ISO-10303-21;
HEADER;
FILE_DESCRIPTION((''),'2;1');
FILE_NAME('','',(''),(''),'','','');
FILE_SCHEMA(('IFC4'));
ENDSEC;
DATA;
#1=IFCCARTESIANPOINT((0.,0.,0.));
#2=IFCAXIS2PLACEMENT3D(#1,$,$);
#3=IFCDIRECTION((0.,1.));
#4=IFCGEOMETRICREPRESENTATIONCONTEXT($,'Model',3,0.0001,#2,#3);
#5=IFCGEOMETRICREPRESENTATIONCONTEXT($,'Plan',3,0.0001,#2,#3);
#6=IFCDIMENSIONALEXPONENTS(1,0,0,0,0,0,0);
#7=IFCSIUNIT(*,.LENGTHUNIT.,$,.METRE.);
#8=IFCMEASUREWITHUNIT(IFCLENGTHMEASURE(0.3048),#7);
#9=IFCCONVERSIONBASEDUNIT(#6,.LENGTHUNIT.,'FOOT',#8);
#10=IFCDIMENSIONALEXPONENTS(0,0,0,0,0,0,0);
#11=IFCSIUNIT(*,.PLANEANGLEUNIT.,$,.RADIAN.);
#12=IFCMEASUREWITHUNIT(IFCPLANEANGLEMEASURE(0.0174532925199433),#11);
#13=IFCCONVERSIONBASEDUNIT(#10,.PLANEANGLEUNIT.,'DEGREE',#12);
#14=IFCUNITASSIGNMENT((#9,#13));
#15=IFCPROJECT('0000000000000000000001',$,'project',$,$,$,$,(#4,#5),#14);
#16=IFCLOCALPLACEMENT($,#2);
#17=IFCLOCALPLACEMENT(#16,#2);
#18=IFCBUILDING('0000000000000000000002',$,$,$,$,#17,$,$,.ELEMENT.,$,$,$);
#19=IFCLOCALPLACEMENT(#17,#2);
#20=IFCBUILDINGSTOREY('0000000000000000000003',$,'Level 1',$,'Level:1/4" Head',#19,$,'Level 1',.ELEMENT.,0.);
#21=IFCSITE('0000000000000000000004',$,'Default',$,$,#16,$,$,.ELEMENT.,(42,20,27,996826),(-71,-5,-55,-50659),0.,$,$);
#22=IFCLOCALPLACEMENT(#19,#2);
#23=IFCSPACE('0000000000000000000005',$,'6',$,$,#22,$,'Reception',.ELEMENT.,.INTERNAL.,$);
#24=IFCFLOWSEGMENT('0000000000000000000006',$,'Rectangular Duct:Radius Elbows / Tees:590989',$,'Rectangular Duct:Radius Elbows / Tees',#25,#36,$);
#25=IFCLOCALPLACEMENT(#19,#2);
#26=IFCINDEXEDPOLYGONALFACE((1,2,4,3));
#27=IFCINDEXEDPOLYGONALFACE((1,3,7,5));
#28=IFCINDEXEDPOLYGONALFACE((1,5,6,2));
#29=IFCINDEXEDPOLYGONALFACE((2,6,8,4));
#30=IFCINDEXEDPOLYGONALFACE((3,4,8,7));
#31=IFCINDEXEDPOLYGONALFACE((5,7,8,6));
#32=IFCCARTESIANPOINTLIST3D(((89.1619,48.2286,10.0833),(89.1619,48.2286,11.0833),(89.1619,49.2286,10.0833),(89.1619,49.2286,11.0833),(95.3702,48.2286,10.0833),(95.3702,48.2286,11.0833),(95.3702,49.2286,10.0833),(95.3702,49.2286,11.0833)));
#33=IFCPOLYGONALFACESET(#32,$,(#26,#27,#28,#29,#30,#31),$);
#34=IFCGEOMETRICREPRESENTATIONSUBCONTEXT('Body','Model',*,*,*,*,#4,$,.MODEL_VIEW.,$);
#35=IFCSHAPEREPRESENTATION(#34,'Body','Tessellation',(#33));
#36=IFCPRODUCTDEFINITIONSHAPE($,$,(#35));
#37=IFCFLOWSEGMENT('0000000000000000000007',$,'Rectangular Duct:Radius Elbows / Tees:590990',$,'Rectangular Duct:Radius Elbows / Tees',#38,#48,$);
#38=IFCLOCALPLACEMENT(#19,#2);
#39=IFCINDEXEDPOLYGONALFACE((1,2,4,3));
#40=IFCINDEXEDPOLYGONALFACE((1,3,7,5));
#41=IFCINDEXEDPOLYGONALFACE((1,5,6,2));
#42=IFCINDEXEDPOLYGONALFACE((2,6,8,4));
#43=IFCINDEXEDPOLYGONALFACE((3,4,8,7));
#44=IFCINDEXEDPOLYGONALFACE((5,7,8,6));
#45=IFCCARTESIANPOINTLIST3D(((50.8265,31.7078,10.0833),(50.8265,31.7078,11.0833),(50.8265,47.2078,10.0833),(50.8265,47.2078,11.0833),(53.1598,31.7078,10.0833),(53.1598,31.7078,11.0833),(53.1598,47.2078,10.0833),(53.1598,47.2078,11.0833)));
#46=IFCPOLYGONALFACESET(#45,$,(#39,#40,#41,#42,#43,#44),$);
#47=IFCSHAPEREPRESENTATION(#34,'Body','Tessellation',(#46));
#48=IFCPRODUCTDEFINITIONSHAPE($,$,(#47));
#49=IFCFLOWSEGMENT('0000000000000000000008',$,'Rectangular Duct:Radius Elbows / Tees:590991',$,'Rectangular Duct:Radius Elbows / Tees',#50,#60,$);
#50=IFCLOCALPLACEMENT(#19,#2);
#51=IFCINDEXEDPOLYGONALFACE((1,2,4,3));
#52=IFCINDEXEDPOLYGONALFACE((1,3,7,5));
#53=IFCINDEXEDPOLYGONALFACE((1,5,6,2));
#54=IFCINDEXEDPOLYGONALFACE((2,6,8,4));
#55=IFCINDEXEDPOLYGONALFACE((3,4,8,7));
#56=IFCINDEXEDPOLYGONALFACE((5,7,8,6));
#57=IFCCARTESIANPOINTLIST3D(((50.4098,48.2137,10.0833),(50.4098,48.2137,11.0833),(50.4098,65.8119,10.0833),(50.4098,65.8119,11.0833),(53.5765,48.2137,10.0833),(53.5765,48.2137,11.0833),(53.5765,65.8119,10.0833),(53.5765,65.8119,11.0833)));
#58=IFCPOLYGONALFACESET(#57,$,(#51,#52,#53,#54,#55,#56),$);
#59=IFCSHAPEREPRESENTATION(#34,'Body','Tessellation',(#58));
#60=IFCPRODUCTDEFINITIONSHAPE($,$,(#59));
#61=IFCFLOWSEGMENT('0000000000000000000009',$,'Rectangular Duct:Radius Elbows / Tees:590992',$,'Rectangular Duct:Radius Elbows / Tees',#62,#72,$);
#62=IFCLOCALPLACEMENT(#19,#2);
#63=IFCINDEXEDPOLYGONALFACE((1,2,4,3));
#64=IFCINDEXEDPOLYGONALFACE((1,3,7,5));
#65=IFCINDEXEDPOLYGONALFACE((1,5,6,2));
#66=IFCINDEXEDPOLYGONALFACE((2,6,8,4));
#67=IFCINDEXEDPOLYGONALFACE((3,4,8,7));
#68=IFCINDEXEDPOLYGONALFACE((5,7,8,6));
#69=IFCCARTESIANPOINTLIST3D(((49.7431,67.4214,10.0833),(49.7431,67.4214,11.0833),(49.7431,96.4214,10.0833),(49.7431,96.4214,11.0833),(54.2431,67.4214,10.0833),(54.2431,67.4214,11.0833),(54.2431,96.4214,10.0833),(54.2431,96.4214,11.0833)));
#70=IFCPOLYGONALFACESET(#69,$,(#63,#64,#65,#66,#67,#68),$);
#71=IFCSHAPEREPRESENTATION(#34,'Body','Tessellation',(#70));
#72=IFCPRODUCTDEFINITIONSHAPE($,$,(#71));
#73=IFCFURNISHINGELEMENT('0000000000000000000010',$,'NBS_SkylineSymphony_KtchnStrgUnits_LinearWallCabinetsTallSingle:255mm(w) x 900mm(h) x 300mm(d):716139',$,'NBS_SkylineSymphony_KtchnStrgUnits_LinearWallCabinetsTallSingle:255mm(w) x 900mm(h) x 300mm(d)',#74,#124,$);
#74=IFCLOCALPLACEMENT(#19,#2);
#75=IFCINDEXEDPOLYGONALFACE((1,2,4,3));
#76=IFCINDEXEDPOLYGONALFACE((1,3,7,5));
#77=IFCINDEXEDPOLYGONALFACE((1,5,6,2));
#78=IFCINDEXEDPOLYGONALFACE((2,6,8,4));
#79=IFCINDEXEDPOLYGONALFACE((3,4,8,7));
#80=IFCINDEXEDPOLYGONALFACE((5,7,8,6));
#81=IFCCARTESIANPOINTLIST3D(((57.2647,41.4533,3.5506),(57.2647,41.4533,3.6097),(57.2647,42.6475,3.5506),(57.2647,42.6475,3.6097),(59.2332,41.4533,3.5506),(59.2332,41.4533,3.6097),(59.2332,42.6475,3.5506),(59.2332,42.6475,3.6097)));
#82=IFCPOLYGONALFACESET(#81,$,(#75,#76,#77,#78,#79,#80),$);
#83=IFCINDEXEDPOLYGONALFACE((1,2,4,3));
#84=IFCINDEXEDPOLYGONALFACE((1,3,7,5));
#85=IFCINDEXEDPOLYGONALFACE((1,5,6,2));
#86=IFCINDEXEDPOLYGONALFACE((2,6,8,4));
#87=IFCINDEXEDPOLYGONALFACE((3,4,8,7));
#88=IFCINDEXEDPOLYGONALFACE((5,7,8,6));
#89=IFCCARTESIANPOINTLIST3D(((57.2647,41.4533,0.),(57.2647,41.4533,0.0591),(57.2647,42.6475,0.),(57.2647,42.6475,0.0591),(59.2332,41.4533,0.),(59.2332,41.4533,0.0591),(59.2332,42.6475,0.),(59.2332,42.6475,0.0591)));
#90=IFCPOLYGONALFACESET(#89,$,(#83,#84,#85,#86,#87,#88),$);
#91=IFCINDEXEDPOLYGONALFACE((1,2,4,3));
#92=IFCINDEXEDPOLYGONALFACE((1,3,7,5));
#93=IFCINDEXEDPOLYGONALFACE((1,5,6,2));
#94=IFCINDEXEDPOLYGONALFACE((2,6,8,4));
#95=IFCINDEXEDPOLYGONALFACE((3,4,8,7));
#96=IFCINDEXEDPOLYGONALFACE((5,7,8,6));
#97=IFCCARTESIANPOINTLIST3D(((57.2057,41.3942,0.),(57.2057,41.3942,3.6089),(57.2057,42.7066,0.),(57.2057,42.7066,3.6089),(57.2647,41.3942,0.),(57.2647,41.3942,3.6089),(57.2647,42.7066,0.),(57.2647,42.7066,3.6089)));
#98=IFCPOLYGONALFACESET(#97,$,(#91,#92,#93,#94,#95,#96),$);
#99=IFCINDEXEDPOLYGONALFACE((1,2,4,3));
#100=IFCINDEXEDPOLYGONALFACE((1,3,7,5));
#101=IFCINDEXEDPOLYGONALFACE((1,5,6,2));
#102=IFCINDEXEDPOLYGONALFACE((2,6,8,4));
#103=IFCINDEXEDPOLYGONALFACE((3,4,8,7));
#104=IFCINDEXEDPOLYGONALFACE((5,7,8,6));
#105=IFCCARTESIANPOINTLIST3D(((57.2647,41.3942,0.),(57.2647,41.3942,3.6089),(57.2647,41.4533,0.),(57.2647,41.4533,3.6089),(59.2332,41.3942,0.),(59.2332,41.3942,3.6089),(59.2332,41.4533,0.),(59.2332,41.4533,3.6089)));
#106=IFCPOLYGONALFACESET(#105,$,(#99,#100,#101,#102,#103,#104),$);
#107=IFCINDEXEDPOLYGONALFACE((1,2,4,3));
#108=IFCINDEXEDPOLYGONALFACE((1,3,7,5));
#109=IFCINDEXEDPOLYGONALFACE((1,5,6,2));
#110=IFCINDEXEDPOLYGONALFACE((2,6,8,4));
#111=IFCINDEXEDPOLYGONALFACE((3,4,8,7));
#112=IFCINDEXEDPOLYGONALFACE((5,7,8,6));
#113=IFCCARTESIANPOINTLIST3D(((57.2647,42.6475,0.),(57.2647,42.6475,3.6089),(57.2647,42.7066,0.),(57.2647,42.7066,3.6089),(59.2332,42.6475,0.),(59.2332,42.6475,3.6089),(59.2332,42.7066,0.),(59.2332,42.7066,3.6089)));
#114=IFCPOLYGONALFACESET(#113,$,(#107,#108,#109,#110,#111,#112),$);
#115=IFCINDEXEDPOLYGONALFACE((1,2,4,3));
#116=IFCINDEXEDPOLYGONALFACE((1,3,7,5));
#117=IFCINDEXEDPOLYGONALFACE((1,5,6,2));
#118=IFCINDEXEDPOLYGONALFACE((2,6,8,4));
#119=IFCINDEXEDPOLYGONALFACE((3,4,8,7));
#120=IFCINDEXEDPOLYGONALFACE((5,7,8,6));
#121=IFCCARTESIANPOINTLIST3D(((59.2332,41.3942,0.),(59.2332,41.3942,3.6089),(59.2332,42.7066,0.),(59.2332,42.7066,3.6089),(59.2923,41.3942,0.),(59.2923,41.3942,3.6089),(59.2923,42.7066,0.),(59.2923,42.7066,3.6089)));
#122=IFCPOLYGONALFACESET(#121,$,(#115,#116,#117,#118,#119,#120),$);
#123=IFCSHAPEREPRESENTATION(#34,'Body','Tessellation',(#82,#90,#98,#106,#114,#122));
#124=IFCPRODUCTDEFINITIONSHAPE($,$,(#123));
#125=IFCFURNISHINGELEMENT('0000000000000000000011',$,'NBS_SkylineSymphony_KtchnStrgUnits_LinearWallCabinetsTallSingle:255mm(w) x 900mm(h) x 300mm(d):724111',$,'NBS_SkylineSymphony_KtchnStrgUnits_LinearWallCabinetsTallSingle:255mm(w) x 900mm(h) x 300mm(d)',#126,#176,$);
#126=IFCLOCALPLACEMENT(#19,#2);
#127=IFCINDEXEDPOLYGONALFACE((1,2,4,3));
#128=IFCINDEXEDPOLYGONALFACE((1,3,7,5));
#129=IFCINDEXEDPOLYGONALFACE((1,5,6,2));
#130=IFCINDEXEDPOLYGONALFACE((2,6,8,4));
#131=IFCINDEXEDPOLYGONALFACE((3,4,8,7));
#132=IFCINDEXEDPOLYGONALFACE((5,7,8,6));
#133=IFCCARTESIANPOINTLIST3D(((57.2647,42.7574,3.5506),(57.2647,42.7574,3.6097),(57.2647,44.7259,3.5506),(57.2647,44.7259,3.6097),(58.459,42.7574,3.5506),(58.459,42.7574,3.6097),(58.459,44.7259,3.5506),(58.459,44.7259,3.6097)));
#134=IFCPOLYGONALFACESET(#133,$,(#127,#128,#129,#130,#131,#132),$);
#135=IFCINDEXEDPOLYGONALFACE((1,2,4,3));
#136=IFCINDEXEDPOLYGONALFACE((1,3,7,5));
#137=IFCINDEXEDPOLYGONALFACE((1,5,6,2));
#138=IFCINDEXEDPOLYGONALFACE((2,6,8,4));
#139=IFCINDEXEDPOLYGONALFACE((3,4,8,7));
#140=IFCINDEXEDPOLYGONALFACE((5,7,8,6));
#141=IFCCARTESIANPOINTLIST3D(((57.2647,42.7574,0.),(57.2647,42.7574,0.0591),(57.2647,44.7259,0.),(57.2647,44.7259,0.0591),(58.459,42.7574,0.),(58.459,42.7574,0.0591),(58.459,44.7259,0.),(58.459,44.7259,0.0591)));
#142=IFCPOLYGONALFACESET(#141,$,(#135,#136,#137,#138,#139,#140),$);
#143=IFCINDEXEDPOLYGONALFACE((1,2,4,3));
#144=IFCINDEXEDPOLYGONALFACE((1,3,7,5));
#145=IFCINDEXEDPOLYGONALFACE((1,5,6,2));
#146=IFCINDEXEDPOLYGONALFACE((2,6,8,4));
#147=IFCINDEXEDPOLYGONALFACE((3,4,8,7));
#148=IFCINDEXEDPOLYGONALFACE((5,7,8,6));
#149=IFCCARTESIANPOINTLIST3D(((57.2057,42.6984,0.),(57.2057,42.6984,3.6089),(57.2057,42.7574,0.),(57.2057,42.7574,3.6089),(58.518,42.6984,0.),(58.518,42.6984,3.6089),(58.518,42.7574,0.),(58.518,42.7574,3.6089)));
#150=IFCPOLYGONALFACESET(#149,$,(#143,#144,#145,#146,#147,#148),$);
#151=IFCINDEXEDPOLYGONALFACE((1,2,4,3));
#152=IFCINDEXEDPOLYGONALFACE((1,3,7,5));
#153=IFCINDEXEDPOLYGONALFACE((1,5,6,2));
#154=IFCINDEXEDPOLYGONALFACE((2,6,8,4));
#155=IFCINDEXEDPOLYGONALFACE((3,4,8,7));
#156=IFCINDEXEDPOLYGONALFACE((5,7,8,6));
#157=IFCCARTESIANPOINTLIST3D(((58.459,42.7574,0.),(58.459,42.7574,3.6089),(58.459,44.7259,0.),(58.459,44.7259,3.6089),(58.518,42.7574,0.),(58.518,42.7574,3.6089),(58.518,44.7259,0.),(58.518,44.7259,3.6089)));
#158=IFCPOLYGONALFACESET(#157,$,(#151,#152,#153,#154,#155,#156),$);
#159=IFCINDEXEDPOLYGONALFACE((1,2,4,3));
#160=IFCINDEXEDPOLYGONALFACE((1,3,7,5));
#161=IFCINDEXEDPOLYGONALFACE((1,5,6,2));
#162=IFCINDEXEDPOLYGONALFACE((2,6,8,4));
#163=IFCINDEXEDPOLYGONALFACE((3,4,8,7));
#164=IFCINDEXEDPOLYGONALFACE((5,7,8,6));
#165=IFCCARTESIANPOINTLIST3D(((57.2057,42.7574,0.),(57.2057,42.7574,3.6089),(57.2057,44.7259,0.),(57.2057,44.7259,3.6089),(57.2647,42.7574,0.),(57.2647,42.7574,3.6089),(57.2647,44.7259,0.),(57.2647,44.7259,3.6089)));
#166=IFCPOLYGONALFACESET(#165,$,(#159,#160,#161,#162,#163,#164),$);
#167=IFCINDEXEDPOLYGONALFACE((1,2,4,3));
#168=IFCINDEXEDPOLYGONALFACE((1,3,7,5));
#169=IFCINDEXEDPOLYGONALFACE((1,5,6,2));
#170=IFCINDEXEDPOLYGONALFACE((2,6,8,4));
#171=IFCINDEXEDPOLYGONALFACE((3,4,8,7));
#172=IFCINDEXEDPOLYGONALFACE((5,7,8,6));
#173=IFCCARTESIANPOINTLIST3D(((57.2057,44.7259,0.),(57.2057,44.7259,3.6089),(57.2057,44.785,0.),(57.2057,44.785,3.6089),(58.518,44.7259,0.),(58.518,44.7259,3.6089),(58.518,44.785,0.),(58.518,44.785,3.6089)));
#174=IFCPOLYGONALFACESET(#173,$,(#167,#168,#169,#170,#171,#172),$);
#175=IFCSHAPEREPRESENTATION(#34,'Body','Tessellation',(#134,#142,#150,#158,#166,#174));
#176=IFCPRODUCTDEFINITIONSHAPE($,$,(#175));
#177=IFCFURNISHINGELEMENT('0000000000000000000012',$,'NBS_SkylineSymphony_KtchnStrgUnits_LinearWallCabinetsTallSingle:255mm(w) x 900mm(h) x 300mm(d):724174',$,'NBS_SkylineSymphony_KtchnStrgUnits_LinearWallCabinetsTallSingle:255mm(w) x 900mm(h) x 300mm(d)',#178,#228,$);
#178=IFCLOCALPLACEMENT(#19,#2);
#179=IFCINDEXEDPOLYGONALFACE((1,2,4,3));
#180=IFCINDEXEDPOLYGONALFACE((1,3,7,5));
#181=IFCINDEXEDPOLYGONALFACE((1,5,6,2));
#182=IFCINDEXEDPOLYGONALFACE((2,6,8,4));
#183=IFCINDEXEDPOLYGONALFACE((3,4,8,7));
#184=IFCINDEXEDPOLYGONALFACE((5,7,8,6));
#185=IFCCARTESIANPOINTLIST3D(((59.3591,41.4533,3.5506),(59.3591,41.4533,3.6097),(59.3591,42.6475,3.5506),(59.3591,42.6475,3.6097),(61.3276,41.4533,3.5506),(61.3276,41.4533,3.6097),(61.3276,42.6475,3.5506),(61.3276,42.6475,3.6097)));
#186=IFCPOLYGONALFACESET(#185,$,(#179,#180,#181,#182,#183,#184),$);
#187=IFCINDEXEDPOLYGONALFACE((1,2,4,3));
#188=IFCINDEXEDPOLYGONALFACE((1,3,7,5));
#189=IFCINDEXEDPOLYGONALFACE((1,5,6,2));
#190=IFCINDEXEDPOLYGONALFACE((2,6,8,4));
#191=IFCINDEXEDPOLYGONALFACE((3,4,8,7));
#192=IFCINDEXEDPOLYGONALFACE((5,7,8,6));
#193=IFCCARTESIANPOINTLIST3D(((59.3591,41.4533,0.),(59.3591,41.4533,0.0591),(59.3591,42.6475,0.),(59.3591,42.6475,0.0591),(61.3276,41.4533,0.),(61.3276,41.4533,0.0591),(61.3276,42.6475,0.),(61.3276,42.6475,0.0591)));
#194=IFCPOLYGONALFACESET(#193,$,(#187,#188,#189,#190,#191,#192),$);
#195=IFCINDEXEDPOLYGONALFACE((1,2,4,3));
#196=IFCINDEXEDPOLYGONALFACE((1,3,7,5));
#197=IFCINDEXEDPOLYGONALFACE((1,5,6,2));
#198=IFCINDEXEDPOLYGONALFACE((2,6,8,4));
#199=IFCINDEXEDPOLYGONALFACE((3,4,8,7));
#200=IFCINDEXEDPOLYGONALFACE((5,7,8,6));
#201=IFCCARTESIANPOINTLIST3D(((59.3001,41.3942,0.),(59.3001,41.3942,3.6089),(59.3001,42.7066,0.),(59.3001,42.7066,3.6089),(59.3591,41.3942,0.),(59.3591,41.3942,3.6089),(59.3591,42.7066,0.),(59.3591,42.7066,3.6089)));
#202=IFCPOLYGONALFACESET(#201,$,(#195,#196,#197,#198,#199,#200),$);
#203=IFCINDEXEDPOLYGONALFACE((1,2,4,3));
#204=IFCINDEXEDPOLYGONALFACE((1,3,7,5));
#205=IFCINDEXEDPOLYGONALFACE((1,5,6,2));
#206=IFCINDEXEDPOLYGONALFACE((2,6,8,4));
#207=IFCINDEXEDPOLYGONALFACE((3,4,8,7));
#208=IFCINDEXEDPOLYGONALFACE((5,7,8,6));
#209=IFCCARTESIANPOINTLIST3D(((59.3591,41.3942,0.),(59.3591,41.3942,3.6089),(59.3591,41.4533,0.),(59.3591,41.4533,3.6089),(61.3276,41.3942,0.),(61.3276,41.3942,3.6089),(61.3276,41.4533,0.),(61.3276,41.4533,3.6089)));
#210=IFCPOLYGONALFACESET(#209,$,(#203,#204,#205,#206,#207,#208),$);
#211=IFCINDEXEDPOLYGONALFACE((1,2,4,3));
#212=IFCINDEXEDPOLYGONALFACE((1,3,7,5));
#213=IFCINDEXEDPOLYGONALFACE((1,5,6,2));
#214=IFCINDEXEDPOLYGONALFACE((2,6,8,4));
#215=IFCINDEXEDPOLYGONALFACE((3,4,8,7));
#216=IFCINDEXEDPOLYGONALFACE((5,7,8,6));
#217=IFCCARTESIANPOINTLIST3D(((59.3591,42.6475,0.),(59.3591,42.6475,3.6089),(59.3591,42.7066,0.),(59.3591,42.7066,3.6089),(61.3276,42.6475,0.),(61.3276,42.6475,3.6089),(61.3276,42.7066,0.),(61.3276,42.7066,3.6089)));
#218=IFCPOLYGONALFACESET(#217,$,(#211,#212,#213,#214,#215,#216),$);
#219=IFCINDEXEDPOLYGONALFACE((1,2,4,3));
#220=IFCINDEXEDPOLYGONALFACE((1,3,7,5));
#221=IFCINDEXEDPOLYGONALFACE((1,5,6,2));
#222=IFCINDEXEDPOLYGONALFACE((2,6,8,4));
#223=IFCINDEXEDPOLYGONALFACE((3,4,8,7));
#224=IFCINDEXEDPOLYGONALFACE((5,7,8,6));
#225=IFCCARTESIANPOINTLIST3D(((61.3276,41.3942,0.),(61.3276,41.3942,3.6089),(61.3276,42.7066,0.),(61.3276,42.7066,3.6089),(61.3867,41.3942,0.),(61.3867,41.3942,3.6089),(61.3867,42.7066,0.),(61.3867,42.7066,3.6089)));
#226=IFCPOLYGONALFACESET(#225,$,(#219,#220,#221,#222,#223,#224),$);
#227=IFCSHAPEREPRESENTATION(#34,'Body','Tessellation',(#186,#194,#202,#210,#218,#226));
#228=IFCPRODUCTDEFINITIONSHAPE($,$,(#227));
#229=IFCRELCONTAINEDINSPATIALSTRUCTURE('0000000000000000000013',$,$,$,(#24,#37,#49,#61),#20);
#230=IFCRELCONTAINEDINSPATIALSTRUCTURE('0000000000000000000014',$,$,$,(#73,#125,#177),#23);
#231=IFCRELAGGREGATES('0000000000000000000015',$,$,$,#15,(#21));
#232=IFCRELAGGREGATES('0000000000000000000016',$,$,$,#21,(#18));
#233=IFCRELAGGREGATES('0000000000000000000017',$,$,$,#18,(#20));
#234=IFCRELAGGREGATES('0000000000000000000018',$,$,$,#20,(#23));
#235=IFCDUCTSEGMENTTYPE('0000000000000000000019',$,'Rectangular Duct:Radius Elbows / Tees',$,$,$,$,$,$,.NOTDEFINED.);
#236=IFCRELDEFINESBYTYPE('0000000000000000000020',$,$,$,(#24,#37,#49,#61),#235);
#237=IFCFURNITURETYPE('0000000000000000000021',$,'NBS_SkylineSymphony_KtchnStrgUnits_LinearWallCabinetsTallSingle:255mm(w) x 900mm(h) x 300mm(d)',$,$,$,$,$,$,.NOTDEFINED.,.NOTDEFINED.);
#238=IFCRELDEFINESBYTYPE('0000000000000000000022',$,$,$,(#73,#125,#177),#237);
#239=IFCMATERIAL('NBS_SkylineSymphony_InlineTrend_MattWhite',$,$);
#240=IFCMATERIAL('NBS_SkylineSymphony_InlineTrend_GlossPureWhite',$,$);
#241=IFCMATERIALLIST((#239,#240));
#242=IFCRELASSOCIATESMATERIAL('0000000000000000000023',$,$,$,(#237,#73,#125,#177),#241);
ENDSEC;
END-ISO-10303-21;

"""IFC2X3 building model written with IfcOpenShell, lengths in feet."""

from ifc_helpers import new_model, entity, si_unit, converted_unit, direction, frame, frame_2d, origin, origin_2d_with_axis, place, context, subcontext, project, spatial, rectangle, extrude, source, transform, mapped, material, material_list, type_object, type_shapes, element, save


model = new_model("IFC2X3")

# Units and contexts
model_context = context("Model", 3, precision=0.0001, world=origin(), true_north=direction((0.0, 1.0)))
plan_context = context("Plan", 3, precision=0.0001, world=origin(), true_north=direction((0.0, 1.0)))
body_context = subcontext(model_context, "Body", "Model", "MODEL_VIEW")
ifc_project = project(units=[converted_unit("LENGTHUNIT", "FOOT", entity("IfcLengthMeasure", 0.3048), si_unit("LENGTHUNIT", "METRE"), dimensions=[1, 0, 0, 0, 0, 0, 0]), converted_unit("PLANEANGLEUNIT", "DEGREE", entity("IfcPlaneAngleMeasure", 0.0174532925199433), si_unit("PLANEANGLEUNIT", "RADIAN"), dimensions=[0, 0, 0, 0, 0, 0, 0])], contexts=[model_context, plan_context])

# Site, building, storey
site_placement = place(None, origin())
site = spatial("IfcSite", under=ifc_project, at=site_placement, Name="Default", CompositionType="ELEMENT", RefLatitude=(42, 20, 27, 996826), RefLongitude=(-71, -5, -55, -50659), RefElevation=0.0)
building_placement = place(site_placement, origin())
building = spatial("IfcBuilding", under=site, at=building_placement, CompositionType="ELEMENT")
storey_placement = place(building_placement, origin())
storey = spatial("IfcBuildingStorey", under=building, at=storey_placement, Name="Level 1", ObjectType="Level:1/4\" Head", LongName="Level 1", CompositionType="ELEMENT", Elevation=0.0)

# Shared definitions
space_1_placement = place(storey_placement, origin())
space_1 = spatial("IfcSpace", under=storey, at=space_1_placement, Name="6", LongName="Reception", CompositionType="ELEMENT", InteriorOrExteriorSpace="INTERNAL")

# Flow segments
duct_segment_type = type_object("IfcDuctSegmentType", Name="Rectangular Duct:Radius Elbows / Tees", PredefinedType="NOTDEFINED")
flow_segment_1_placement = place(storey_placement, origin())
element("IfcFlowSegment", 1, at=flow_segment_1_placement, inside=storey, type_object=duct_segment_type, Name="Rectangular Duct:Radius Elbows / Tees:590989", ObjectType="Rectangular Duct:Radius Elbows / Tees", context=body_context, shape_type="SweptSolid", body=[
    extrude(rectangle(XDim=6.2083, YDim=1.0, at=frame_2d((0.0, 0.0), x_axis=(1.0, 0.0))), frame((92.266, 48.7286, 10.0833)), (0.0, 0.0, 1.0), 1.0),
])
flow_segment_2_placement = place(storey_placement, origin())
element("IfcFlowSegment", 2, at=flow_segment_2_placement, inside=storey, type_object=duct_segment_type, Name="Rectangular Duct:Radius Elbows / Tees:590990", ObjectType="Rectangular Duct:Radius Elbows / Tees", context=body_context, shape_type="SweptSolid", body=[
    extrude(rectangle(XDim=15.5, YDim=2.3333, at=frame_2d((0.0, 0.0), x_axis=(1.0, 0.0))), frame((51.9931, 39.4578, 10.0833), z_axis=(0.0, 0.0, 1.0), x_axis=(0.0, -1.0, 0.0)), (0.0, 0.0, 1.0), 1.0),
])
flow_segment_3_placement = place(storey_placement, origin())
element("IfcFlowSegment", 3, at=flow_segment_3_placement, inside=storey, type_object=duct_segment_type, Name="Rectangular Duct:Radius Elbows / Tees:590991", ObjectType="Rectangular Duct:Radius Elbows / Tees", context=body_context, shape_type="SweptSolid", body=[
    extrude(rectangle(XDim=17.5982, YDim=3.1667, at=frame_2d((0.0, 0.0), x_axis=(1.0, 0.0))), frame((51.9931, 57.0128, 10.0833), z_axis=(0.0, 0.0, 1.0), x_axis=(0.0, -1.0, 0.0)), (0.0, 0.0, 1.0), 1.0),
])
flow_segment_4_placement = place(storey_placement, origin())
element("IfcFlowSegment", 4, at=flow_segment_4_placement, inside=storey, type_object=duct_segment_type, Name="Rectangular Duct:Radius Elbows / Tees:590992", ObjectType="Rectangular Duct:Radius Elbows / Tees", context=body_context, shape_type="SweptSolid", body=[
    extrude(rectangle(XDim=29.0, YDim=4.5, at=origin_2d_with_axis()), frame((51.9931, 81.9214, 10.0833), z_axis=(0.0, 0.0, 1.0), x_axis=(0.0, 1.0, 0.0)), (0.0, 0.0, 1.0), 1.0),
])

# Furnishing elements
ifc_material_1 = material(Name="NBS_SkylineSymphony_InlineTrend_MattWhite")
ifc_material_2 = material(Name="NBS_SkylineSymphony_InlineTrend_GlossPureWhite")
ifc_material_list = material_list([ifc_material_1, ifc_material_2])
furniture_type = type_object("IfcFurnitureType", Name="NBS_SkylineSymphony_KtchnStrgUnits_LinearWallCabinetsTallSingle:255mm(w) x 900mm(h) x 300mm(d)", AssemblyPlace="NOTDEFINED", material=ifc_material_list)
shared_shape_1 = source(origin(), body_context, "Body", "SweptSolid", [
    extrude(rectangle(XDim=1.9685, YDim=1.1942, at=origin_2d_with_axis()), frame((-0.2379, 0.0, 3.5506), z_axis=(0.0, 0.0, 1.0), x_axis=(0.0, 1.0, 0.0)), (0.0, 0.0, 1.0), 0.0591),
    extrude(rectangle(XDim=1.9685, YDim=1.1942, at=origin_2d_with_axis()), frame((-0.2379, 0.0, 0.0), z_axis=(0.0, 0.0, 1.0), x_axis=(0.0, 1.0, 0.0)), (0.0, 0.0, 1.0), 0.0591),
    extrude(rectangle(XDim=1.3123, YDim=0.0591, at=origin_2d_with_axis()), frame((-0.2379, 1.0138, 0.0), z_axis=(0.0, 0.0, 1.0), x_axis=(-1.0, 0.0, 0.0)), (0.0, 0.0, 1.0), 3.6089),
    extrude(rectangle(XDim=1.9685, YDim=0.0591, at=origin_2d_with_axis()), frame((-0.8645, 0.0, 0.0), z_axis=(0.0, 0.0, 1.0), x_axis=(0.0, -1.0, 0.0)), (0.0, 0.0, 1.0), 3.6089),
    extrude(rectangle(XDim=0.0591, YDim=1.9685, at=origin_2d_with_axis()), frame((0.3888, 0.0, 0.0)), (0.0, 0.0, 1.0), 3.6089),
    extrude(rectangle(XDim=0.0591, YDim=1.3123, at=frame_2d((0.0, 0.0), x_axis=(1.0, 0.0))), frame((-0.2379, -1.0138, 0.0), z_axis=(0.0, 0.0, 1.0), x_axis=(0.0, 1.0, 0.0)), (0.0, 0.0, 1.0), 3.6089),
])
type_shapes(furniture_type, [shared_shape_1])
for number, where, z_axis, x_axis, name in (
    (5, (58.249, 42.2883, 0.0), (0.0, 0.0, 1.0), (0.0, 1.0, 0.0), "NBS_SkylineSymphony_KtchnStrgUnits_LinearWallCabinetsTallSingle:255mm(w) x 900mm(h) x 300mm(d):716139"),
    (6, (57.624, 43.7417, 0.0), (0.0, 0.0, 1.0), (-1.0, 0.0, 0.0), "NBS_SkylineSymphony_KtchnStrgUnits_LinearWallCabinetsTallSingle:255mm(w) x 900mm(h) x 300mm(d):724111"),
    (7, (60.3434, 42.2883, 0.0), (0.0, 0.0, 1.0), (0.0, 1.0, 0.0), "NBS_SkylineSymphony_KtchnStrgUnits_LinearWallCabinetsTallSingle:255mm(w) x 900mm(h) x 300mm(d):724174"),
):
    element("IfcFurnishingElement", number, at=place(space_1_placement, frame(where, z_axis=z_axis, x_axis=x_axis)), inside=space_1, type_object=furniture_type, material=ifc_material_list, Name=name, ObjectType="NBS_SkylineSymphony_KtchnStrgUnits_LinearWallCabinetsTallSingle:255mm(w) x 900mm(h) x 300mm(d)", context=body_context, shape_type="MappedRepresentation", body=[
        mapped(shared_shape_1, transform((0.0, 0.0, 0.0), scale=1.0)),
    ])

save(model, "model.ifc")
